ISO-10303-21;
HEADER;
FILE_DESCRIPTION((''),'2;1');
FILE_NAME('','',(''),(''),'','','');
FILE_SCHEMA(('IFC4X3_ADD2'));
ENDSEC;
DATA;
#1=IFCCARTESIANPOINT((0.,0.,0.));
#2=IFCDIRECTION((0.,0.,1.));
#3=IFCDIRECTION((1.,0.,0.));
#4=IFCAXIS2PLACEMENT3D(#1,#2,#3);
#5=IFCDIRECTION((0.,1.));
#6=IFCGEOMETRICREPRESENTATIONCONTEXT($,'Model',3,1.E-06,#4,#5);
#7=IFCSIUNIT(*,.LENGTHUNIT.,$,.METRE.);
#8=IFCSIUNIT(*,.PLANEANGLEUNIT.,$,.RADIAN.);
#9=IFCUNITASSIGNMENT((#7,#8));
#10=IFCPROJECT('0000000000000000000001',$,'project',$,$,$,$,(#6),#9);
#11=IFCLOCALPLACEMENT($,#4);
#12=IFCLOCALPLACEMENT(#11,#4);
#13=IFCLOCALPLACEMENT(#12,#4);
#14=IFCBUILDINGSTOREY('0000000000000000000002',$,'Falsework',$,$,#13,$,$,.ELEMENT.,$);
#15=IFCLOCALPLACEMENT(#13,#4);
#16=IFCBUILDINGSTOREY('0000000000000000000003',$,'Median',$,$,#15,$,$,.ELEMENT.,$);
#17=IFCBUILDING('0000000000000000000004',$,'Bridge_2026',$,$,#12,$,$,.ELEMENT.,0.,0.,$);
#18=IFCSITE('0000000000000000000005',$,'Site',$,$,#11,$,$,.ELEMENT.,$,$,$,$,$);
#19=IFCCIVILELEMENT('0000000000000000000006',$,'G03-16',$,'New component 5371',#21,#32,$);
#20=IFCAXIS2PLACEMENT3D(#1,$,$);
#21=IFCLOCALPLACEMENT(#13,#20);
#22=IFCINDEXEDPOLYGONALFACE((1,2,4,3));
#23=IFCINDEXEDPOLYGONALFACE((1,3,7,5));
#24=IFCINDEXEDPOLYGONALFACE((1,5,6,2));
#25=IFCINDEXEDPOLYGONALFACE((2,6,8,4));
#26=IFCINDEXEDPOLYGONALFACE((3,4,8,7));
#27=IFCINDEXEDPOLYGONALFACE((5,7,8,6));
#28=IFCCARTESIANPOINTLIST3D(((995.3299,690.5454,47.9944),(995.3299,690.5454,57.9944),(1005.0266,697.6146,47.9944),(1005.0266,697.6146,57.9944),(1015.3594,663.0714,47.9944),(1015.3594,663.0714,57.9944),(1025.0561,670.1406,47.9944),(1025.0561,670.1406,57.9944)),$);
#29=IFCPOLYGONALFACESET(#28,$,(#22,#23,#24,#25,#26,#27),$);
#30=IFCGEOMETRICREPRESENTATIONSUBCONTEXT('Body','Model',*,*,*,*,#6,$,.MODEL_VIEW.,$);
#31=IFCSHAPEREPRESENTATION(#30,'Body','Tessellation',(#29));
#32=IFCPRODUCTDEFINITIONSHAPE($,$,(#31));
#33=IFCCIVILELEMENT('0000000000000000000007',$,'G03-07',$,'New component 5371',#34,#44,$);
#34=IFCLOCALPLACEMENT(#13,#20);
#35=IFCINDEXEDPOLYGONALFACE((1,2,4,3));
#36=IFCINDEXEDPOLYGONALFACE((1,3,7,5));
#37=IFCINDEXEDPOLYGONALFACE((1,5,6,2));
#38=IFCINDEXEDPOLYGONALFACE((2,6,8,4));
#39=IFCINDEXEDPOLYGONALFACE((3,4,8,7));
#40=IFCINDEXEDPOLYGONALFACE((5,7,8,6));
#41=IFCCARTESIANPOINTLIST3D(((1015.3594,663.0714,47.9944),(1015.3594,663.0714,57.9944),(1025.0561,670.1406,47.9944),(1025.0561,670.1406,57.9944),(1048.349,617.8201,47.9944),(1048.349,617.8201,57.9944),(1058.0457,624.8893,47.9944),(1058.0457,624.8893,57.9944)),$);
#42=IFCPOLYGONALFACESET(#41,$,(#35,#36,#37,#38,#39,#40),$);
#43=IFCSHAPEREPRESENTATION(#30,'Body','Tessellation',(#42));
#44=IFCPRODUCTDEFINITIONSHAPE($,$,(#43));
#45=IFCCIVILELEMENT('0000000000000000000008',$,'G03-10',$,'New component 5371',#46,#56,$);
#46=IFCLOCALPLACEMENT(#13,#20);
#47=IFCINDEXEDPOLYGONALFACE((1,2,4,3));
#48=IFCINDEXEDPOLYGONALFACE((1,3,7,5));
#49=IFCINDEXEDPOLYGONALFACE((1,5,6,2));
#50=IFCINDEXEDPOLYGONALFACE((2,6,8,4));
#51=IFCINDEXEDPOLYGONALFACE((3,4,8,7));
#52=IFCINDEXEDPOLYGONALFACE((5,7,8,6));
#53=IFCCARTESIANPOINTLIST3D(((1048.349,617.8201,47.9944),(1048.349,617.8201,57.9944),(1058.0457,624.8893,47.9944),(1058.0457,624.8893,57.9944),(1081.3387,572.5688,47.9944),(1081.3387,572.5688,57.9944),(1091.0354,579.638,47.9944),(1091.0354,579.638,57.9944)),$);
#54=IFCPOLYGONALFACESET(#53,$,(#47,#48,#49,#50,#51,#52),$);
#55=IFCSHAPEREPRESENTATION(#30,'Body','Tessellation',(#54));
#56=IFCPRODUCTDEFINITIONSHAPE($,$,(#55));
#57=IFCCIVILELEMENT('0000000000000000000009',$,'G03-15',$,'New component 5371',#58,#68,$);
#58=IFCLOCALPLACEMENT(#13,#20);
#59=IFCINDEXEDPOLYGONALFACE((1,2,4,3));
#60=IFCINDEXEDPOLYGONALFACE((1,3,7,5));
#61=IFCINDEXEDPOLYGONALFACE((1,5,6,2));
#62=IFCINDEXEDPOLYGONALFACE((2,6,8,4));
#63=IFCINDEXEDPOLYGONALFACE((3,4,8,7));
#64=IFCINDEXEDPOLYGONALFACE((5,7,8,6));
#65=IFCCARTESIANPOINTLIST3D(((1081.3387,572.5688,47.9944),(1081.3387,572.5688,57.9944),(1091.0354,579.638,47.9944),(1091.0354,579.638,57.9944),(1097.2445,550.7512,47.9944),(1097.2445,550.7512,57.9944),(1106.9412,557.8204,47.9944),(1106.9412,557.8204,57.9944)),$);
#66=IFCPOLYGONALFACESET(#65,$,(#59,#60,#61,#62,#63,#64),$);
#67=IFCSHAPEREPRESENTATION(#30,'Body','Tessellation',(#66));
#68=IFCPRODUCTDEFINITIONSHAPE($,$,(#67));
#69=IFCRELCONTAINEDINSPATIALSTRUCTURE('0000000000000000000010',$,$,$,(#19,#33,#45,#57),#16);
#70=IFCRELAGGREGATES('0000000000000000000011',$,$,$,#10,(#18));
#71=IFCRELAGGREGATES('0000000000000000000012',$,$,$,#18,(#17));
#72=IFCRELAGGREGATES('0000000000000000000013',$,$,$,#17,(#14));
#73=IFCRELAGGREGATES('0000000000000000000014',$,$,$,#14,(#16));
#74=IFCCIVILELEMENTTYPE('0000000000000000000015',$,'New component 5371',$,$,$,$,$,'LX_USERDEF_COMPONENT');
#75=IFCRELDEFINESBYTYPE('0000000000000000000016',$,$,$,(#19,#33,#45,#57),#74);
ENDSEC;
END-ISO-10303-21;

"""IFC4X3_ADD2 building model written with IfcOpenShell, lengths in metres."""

from ifc_helpers import new_model, si_unit, direction, frame, frame_2d, origin_with_axes, place, context, subcontext, project, spatial, rectangle, extrude, type_object, element, save


model = new_model("IFC4X3_ADD2")

# Units and contexts
model_context = context("Model", 3, precision=1e-06, world=origin_with_axes(), true_north=direction((0.0, 1.0)))
body_context = subcontext(model_context, "Body", "Model", "MODEL_VIEW")
ifc_project = project(units=[si_unit("LENGTHUNIT", "METRE"), si_unit("PLANEANGLEUNIT", "RADIAN")], contexts=[model_context])

# Site, building, storeys
site_placement = place(None, origin_with_axes())
site = spatial("IfcSite", under=ifc_project, at=site_placement, Name="Site", CompositionType="ELEMENT")
building_placement = place(site_placement, origin_with_axes())
building = spatial("IfcBuilding", under=site, at=building_placement, Name="Bridge_2026", CompositionType="ELEMENT", ElevationOfRefHeight=0.0, ElevationOfTerrain=0.0)
storey_1_placement = place(building_placement, origin_with_axes())
storey_1 = spatial("IfcBuildingStorey", under=building, at=storey_1_placement, Name="Falsework", CompositionType="ELEMENT")
storey_2_placement = place(storey_1_placement, origin_with_axes())
storey_2 = spatial("IfcBuildingStorey", under=storey_1, at=storey_2_placement, Name="Median", CompositionType="ELEMENT")

# Civil elements
civil_element_type = type_object("IfcCivilElementType", Name="New component 5371", ElementType="LX_USERDEF_COMPONENT")
civil_element_1_placement = place(storey_2_placement, frame((1015.3594, 663.0714, 47.9944), z_axis=(0.0, 0.0, 1.0), x_axis=(0.808059, 0.589101, 0.0)))
element("IfcCivilElement", 1, at=civil_element_1_placement, inside=storey_2, type_object=civil_element_type, Name="G03-16", ObjectType="New component 5371", context=body_context, shape_type="SweptSolid", body=[
    extrude(rectangle(XDim=12.0, YDim=34.0, at=frame_2d((6.0, 17.0), x_axis=(1.0, 0.0))), origin_with_axes(), (0.0, 0.0, 1.0), 10.0),
])
for number, where, z_axis, x_axis, name in (
    (2, (1048.349, 617.8201, 47.9944), (0.0, 0.0, 1.0), (0.808059, 0.589101, 0.0), "G03-07"),
    (3, (1081.3387, 572.5688, 47.9944), (0.0, 0.0, 1.0), (0.808059, 0.589101, 0.0), "G03-10"),
):
    element("IfcCivilElement", number, at=place(storey_2_placement, frame(where, z_axis=z_axis, x_axis=x_axis)), inside=storey_2, type_object=civil_element_type, Name=name, ObjectType="New component 5371", context=body_context, shape_type="SweptSolid", body=[
        extrude(rectangle(XDim=12.0, YDim=56.0, at=frame_2d((6.0, 28.0), x_axis=(1.0, 0.0))), origin_with_axes(), (0.0, 0.0, 1.0), 10.0),
    ])
civil_element_2_placement = place(storey_2_placement, frame((1097.2445, 550.7512, 47.9944), z_axis=(0.0, 0.0, 1.0), x_axis=(0.808059, 0.589101, 0.0)))
element("IfcCivilElement", 4, at=civil_element_2_placement, inside=storey_2, type_object=civil_element_type, Name="G03-15", ObjectType="New component 5371", context=body_context, shape_type="SweptSolid", body=[
    extrude(rectangle(XDim=12.0, YDim=27.0, at=frame_2d((6.0, 13.5), x_axis=(1.0, 0.0))), origin_with_axes(), (0.0, 0.0, 1.0), 10.0),
])

save(model, "model.ifc")
